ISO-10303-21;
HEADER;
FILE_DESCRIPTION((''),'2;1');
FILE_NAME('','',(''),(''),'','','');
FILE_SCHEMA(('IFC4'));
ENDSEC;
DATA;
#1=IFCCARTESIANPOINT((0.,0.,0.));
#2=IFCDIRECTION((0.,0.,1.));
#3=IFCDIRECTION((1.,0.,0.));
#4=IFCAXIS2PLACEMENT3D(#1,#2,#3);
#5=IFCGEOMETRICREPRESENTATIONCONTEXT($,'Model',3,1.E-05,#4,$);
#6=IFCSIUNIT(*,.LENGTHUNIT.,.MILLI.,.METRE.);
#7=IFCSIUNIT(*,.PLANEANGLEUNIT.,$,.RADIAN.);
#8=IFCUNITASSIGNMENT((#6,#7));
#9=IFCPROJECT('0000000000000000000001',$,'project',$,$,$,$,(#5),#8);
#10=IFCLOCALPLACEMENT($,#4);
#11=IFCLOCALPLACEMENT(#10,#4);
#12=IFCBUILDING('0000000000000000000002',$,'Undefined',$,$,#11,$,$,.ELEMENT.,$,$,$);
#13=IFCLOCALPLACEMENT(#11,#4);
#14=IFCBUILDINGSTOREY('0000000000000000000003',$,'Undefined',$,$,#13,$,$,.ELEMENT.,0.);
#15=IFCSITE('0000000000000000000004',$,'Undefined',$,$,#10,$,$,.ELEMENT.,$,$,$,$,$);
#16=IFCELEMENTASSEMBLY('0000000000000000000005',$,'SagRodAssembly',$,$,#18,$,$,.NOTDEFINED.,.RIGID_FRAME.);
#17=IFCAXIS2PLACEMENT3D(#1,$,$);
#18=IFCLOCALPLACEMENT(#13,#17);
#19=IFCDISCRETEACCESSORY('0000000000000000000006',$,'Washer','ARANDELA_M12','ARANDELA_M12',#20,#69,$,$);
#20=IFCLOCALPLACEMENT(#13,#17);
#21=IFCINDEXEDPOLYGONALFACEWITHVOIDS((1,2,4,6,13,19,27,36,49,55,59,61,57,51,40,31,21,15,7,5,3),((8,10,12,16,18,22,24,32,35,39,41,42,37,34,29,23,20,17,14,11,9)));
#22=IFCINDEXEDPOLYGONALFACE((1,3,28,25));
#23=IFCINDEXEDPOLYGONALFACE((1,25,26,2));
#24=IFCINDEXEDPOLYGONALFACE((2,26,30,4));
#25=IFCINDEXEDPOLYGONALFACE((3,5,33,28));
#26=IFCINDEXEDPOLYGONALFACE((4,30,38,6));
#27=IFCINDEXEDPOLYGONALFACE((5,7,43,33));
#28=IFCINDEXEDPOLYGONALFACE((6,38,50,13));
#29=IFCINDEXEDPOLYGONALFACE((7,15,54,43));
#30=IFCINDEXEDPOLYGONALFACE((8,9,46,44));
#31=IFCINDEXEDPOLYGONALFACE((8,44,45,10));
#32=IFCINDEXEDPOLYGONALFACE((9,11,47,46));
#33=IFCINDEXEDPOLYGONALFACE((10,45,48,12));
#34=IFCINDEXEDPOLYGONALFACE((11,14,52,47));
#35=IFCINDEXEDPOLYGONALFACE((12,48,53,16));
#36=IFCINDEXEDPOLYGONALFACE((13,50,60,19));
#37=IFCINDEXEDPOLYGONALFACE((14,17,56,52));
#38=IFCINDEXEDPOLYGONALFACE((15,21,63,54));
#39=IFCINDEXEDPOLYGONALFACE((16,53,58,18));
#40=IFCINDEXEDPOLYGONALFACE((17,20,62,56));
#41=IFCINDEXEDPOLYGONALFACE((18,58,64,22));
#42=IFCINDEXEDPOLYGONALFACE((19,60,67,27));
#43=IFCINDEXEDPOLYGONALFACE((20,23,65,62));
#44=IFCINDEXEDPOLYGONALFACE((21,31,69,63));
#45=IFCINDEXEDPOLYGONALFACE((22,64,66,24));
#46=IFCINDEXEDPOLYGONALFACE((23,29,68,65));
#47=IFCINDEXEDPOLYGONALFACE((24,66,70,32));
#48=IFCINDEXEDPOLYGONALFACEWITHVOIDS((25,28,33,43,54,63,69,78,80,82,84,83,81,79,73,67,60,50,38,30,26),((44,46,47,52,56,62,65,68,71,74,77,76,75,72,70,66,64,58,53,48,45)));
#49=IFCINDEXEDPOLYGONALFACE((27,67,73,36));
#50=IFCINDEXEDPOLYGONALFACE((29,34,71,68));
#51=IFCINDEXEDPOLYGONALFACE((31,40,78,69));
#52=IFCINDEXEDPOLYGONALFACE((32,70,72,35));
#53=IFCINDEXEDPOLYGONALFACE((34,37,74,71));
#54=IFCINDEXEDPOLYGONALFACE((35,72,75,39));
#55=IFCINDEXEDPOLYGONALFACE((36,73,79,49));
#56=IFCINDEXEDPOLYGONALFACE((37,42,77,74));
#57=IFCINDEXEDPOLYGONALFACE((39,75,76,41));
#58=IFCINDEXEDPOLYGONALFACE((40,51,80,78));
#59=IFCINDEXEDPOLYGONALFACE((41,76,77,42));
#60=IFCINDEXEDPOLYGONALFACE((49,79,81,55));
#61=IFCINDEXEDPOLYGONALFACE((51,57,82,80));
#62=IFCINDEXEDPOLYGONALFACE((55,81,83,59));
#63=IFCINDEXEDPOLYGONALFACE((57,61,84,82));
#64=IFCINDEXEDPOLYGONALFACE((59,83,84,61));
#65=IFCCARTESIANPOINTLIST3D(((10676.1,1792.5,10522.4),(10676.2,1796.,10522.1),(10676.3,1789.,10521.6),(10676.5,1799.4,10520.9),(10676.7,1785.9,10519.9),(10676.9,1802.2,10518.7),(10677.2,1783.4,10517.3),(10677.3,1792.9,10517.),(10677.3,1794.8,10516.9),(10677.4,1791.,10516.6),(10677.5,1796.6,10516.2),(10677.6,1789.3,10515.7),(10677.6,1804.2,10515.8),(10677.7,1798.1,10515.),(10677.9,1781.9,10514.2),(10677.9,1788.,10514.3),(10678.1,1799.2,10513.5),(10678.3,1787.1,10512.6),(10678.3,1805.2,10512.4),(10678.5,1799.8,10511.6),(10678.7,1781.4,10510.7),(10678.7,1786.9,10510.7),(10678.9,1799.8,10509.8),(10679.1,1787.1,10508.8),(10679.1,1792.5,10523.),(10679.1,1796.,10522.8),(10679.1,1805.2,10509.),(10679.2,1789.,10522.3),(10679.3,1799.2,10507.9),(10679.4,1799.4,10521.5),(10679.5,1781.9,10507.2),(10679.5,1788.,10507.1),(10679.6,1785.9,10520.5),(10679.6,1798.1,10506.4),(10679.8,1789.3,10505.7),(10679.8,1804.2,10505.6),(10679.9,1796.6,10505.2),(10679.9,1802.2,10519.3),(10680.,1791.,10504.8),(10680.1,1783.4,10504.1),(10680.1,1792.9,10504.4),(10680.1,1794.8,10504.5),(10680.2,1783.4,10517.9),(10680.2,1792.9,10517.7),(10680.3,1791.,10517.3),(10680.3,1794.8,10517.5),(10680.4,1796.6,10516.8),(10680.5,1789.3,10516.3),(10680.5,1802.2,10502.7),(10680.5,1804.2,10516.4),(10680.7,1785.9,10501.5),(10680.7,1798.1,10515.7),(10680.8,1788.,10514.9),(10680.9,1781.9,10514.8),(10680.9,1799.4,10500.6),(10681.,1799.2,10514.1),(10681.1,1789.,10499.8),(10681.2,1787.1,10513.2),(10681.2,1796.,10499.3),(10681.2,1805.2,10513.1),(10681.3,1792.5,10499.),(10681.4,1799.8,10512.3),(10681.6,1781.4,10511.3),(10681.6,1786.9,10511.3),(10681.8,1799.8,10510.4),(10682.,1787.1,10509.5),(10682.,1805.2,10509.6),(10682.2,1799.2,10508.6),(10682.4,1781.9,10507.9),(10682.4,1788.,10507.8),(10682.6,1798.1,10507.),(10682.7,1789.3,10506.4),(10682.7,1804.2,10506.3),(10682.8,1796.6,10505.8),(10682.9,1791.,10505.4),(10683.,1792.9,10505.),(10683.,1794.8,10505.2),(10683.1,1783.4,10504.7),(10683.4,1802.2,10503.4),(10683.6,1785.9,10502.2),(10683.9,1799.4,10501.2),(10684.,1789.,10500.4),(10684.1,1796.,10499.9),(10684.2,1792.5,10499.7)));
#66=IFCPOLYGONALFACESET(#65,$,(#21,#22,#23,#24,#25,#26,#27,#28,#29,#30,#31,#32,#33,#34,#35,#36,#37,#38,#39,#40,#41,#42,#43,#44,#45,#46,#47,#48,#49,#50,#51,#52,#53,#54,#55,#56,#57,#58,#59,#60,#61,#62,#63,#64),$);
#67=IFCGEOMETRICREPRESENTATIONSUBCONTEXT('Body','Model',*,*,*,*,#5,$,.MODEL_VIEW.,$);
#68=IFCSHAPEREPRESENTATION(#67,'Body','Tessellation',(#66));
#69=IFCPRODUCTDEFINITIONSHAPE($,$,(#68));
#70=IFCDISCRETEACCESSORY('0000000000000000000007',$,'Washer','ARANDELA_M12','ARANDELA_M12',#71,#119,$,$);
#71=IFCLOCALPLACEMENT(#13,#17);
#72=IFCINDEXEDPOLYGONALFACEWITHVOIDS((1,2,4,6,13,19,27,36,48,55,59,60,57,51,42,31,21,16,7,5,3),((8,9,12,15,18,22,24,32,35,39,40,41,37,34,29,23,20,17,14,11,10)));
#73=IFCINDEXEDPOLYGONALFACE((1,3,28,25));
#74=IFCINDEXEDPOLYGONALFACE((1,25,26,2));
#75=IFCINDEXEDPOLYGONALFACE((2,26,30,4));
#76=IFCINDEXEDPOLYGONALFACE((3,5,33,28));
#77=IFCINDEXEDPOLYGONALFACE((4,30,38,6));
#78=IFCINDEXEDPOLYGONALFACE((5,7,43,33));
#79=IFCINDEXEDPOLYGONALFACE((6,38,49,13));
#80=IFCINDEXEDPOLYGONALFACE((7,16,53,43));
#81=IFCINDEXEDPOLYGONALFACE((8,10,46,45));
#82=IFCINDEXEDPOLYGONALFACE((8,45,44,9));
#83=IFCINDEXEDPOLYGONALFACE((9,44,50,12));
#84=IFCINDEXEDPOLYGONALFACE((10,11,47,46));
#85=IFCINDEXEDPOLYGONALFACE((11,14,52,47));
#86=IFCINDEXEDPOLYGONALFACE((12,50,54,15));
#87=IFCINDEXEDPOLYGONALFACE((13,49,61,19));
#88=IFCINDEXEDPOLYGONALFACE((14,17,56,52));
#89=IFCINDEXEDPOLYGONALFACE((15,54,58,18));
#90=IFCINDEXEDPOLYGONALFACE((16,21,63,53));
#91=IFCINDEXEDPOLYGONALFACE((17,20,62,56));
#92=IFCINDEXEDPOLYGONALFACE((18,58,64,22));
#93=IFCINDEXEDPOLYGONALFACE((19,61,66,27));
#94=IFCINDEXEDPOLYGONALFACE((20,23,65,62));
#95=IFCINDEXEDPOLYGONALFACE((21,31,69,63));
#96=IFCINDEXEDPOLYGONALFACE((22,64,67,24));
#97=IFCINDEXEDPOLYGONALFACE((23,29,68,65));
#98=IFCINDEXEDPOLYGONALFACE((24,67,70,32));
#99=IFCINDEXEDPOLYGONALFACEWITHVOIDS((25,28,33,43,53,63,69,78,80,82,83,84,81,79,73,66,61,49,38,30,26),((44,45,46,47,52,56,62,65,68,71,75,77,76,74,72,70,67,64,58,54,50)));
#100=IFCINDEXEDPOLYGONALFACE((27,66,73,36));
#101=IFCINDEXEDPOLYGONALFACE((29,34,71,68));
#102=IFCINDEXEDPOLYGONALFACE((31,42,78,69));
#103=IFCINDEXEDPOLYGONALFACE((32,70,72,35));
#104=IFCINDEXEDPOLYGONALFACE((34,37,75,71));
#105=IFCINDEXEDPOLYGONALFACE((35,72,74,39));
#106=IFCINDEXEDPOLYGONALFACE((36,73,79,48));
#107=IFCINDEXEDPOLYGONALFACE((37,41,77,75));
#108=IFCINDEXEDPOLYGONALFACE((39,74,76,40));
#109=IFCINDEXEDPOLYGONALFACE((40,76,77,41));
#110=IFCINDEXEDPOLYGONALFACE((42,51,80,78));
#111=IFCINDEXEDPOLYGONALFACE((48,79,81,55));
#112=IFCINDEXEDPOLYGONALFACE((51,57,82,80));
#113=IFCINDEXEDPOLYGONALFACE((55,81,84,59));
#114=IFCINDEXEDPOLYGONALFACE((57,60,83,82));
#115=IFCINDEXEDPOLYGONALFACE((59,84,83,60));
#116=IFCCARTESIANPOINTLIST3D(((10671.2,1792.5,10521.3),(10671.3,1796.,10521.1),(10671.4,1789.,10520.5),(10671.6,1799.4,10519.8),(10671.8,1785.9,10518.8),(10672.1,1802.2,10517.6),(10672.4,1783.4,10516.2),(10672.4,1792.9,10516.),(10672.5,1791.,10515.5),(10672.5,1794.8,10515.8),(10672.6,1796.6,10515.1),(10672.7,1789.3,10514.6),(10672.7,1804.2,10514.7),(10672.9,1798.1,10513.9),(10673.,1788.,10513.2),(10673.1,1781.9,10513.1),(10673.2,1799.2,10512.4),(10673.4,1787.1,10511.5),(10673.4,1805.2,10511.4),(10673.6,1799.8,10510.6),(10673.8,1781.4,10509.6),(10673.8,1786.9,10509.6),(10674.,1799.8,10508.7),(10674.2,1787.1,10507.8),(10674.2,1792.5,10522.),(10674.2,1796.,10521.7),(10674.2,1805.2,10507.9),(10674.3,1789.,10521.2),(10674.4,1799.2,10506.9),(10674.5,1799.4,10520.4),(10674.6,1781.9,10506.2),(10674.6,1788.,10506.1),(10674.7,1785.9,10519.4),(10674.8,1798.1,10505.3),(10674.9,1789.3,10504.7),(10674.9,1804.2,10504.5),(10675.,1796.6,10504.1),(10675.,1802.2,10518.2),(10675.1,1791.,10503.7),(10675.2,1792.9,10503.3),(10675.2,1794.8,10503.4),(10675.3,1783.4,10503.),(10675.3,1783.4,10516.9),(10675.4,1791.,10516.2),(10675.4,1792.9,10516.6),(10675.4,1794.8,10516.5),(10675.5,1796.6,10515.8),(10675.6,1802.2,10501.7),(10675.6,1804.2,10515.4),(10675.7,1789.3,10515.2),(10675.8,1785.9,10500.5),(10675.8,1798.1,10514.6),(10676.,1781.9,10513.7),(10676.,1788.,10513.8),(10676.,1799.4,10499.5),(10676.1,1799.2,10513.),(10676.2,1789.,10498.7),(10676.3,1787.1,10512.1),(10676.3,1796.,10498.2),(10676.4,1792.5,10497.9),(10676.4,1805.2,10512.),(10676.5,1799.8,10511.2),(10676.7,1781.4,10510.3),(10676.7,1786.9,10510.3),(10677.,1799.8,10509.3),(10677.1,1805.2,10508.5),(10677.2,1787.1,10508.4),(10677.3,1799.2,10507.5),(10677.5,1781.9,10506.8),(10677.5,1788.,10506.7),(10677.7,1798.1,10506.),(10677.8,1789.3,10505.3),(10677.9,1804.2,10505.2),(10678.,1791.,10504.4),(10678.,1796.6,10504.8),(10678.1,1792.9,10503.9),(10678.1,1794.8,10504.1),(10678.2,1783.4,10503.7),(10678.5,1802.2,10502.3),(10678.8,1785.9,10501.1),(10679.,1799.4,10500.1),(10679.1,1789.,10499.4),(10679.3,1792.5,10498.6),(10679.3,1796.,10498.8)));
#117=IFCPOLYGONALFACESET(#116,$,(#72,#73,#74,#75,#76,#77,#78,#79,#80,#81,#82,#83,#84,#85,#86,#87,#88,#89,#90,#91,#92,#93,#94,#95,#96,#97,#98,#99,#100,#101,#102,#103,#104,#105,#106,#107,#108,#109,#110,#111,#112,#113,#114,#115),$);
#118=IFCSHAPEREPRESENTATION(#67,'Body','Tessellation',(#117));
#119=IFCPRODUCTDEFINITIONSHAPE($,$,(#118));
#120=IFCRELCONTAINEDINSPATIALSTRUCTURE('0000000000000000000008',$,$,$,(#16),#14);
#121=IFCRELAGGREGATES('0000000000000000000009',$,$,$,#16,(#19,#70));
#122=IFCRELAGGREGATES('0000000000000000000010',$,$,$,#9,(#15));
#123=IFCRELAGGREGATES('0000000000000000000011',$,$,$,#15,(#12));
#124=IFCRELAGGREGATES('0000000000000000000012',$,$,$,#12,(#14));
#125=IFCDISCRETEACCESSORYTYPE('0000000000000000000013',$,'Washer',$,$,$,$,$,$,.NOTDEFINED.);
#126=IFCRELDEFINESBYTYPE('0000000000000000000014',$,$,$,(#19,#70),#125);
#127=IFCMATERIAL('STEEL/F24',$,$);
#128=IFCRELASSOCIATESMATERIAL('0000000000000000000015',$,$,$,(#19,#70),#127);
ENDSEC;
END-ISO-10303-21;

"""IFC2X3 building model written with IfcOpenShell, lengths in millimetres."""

from ifc_helpers import new_model, si_unit, frame, origin_with_axes, origin_2d_with_axis, place, context, subcontext, project, spatial, hollow_circle, extrude, material, type_object, element, aggregate, save


model = new_model("IFC2X3")

# Units and contexts
model_context = context("Model", 3, precision=1e-05, world=origin_with_axes())
body_context = subcontext(model_context, "Body", "Model", "MODEL_VIEW")
ifc_project = project(units=[si_unit("LENGTHUNIT", "METRE", prefix="MILLI"), si_unit("PLANEANGLEUNIT", "RADIAN")], contexts=[model_context])

# Site, building, storey
site_placement = place(None, origin_with_axes())
site = spatial("IfcSite", under=ifc_project, at=site_placement, Name="Undefined", CompositionType="ELEMENT")
building_placement = place(site_placement, origin_with_axes())
building = spatial("IfcBuilding", under=site, at=building_placement, Name="Undefined", CompositionType="ELEMENT")
storey_placement = place(building_placement, origin_with_axes())
storey = spatial("IfcBuildingStorey", under=building, at=storey_placement, Name="Undefined", CompositionType="ELEMENT", Elevation=0.0)

# Shared definitions
ifc_material_1 = material(Name="STEEL/F24")

# Element assembly
assembly_1_placement = place(storey_placement, origin_with_axes())
assembly_1 = element("IfcElementAssembly", 1, at=assembly_1_placement, inside=storey, Name="SagRodAssembly", AssemblyPlace="NOTDEFINED", PredefinedType="RIGID_FRAME")

# Discrete accessories
discrete_accessory_type_1 = type_object("IfcDiscreteAccessoryType", Name="Washer")
discrete_accessory_1_placement = place(assembly_1_placement, frame((10678.7, 1793.4, 10510.7), z_axis=(-0.214887, 0.0, 0.976639), x_axis=(0.976639, 0.0, 0.214887)))
discrete_accessory_1 = element("IfcDiscreteAccessory", 2, at=discrete_accessory_1_placement, type_object=discrete_accessory_type_1, material=ifc_material_1, Name="Washer", Description="ARANDELA_M12", ObjectType="ARANDELA_M12", context=body_context, shape_type="SweptSolid", body=[
    extrude(hollow_circle(Radius=12.0, WallThickness=5.5, at=origin_2d_with_axis()), frame((3.0, 0.0, 0.0), z_axis=(-1.0, 0.0, 0.0), x_axis=(0.0, -1.0, 0.0)), (0.0, 0.0, 1.0), 3.0),
])
discrete_accessory_2_placement = place(assembly_1_placement, frame((10673.8, 1793.4, 10509.6), z_axis=(-0.214887, 0.0, 0.976639), x_axis=(0.976639, 0.0, 0.214887)))
discrete_accessory_2 = element("IfcDiscreteAccessory", 3, at=discrete_accessory_2_placement, type_object=discrete_accessory_type_1, material=ifc_material_1, Name="Washer", Description="ARANDELA_M12", ObjectType="ARANDELA_M12", context=body_context, shape_type="SweptSolid", body=[
    extrude(hollow_circle(Radius=12.0, WallThickness=5.5, at=origin_2d_with_axis()), frame((3.0, 0.0, 0.0), z_axis=(-1.0, 0.0, 0.0), x_axis=(0.0, -1.0, 0.0)), (0.0, 0.0, 1.0), 3.0),
])
aggregate(assembly_1, [discrete_accessory_1, discrete_accessory_2])

save(model, "model.ifc")
